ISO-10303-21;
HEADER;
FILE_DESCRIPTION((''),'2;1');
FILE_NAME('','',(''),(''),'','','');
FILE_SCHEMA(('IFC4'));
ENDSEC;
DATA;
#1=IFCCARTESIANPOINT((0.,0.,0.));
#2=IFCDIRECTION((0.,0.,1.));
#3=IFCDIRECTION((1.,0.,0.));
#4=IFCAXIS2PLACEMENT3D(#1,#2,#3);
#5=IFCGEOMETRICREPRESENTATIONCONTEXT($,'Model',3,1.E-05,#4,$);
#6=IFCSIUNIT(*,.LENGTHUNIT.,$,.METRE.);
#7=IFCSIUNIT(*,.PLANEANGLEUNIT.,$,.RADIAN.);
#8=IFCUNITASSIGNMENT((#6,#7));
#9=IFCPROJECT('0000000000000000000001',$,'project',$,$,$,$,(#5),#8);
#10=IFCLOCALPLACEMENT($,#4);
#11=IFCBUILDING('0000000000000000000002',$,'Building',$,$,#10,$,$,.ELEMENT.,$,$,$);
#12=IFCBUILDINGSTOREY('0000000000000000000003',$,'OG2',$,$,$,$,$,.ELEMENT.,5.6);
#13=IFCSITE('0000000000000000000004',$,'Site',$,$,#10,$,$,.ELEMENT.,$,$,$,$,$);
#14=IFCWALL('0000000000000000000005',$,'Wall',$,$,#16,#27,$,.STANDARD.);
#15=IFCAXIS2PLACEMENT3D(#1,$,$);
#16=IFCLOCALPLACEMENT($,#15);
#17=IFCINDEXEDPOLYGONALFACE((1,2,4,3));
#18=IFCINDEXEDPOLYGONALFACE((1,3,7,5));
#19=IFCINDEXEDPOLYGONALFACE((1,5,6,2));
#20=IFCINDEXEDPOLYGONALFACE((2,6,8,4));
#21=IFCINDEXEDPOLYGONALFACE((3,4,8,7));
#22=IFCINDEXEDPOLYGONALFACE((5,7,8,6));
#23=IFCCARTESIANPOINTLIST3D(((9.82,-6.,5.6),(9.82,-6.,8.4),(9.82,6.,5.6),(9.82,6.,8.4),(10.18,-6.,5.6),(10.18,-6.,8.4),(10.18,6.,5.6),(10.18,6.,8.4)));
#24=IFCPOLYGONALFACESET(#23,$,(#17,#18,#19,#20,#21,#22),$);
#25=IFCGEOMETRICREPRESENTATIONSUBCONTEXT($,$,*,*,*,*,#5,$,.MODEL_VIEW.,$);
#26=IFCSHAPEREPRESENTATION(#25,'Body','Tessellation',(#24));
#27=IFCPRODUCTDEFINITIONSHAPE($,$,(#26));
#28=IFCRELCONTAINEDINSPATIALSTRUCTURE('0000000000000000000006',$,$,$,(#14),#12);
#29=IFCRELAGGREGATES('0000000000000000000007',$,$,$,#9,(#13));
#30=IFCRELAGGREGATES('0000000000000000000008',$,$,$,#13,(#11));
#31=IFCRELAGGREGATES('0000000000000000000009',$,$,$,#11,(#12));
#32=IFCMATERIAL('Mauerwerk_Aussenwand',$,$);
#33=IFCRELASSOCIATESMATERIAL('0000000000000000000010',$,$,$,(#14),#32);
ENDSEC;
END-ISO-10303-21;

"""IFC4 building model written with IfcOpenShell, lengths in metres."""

from ifc_helpers import new_model, si_unit, frame, frame_2d, origin, origin_with_axes, place, context, subcontext, project, spatial, rectangle, extrude, material, element, save


model = new_model("IFC4")

# Units and contexts
model_context = context("Model", 3, precision=1e-05, world=origin_with_axes())
sub_context = subcontext(model_context, None, None, "MODEL_VIEW")
ifc_project = project(units=[si_unit("LENGTHUNIT", "METRE"), si_unit("PLANEANGLEUNIT", "RADIAN")], contexts=[model_context])

# Site, building, storey
placement_1 = place(None, origin_with_axes())
site = spatial("IfcSite", under=ifc_project, at=placement_1, Name="Site", CompositionType="ELEMENT")
building = spatial("IfcBuilding", under=site, at=placement_1, Name="Building", CompositionType="ELEMENT")
storey = spatial("IfcBuildingStorey", under=building, Name="OG2", CompositionType="ELEMENT", Elevation=5.6)

# Wall
ifc_material = material(Name="Mauerwerk_Aussenwand")
placement_2 = place(None, origin_with_axes())
placement_3 = place(placement_2, frame((0.0, 0.0, 5.6)))
wall_placement = place(placement_3, frame((10.0, -6.0, 0.0), x_axis=(0.0, 1.0, 0.0)))
element("IfcWall", 1, at=wall_placement, inside=storey, material=ifc_material, Name="Wall", PredefinedType="STANDARD", context=sub_context, shape_type="SweptSolid", body=[
    extrude(rectangle(XDim=12.0, YDim=0.36, at=frame_2d((6.0, 0.0))), origin(), (0.0, 0.0, 1.0), 2.8),
])

save(model, "model.ifc")
